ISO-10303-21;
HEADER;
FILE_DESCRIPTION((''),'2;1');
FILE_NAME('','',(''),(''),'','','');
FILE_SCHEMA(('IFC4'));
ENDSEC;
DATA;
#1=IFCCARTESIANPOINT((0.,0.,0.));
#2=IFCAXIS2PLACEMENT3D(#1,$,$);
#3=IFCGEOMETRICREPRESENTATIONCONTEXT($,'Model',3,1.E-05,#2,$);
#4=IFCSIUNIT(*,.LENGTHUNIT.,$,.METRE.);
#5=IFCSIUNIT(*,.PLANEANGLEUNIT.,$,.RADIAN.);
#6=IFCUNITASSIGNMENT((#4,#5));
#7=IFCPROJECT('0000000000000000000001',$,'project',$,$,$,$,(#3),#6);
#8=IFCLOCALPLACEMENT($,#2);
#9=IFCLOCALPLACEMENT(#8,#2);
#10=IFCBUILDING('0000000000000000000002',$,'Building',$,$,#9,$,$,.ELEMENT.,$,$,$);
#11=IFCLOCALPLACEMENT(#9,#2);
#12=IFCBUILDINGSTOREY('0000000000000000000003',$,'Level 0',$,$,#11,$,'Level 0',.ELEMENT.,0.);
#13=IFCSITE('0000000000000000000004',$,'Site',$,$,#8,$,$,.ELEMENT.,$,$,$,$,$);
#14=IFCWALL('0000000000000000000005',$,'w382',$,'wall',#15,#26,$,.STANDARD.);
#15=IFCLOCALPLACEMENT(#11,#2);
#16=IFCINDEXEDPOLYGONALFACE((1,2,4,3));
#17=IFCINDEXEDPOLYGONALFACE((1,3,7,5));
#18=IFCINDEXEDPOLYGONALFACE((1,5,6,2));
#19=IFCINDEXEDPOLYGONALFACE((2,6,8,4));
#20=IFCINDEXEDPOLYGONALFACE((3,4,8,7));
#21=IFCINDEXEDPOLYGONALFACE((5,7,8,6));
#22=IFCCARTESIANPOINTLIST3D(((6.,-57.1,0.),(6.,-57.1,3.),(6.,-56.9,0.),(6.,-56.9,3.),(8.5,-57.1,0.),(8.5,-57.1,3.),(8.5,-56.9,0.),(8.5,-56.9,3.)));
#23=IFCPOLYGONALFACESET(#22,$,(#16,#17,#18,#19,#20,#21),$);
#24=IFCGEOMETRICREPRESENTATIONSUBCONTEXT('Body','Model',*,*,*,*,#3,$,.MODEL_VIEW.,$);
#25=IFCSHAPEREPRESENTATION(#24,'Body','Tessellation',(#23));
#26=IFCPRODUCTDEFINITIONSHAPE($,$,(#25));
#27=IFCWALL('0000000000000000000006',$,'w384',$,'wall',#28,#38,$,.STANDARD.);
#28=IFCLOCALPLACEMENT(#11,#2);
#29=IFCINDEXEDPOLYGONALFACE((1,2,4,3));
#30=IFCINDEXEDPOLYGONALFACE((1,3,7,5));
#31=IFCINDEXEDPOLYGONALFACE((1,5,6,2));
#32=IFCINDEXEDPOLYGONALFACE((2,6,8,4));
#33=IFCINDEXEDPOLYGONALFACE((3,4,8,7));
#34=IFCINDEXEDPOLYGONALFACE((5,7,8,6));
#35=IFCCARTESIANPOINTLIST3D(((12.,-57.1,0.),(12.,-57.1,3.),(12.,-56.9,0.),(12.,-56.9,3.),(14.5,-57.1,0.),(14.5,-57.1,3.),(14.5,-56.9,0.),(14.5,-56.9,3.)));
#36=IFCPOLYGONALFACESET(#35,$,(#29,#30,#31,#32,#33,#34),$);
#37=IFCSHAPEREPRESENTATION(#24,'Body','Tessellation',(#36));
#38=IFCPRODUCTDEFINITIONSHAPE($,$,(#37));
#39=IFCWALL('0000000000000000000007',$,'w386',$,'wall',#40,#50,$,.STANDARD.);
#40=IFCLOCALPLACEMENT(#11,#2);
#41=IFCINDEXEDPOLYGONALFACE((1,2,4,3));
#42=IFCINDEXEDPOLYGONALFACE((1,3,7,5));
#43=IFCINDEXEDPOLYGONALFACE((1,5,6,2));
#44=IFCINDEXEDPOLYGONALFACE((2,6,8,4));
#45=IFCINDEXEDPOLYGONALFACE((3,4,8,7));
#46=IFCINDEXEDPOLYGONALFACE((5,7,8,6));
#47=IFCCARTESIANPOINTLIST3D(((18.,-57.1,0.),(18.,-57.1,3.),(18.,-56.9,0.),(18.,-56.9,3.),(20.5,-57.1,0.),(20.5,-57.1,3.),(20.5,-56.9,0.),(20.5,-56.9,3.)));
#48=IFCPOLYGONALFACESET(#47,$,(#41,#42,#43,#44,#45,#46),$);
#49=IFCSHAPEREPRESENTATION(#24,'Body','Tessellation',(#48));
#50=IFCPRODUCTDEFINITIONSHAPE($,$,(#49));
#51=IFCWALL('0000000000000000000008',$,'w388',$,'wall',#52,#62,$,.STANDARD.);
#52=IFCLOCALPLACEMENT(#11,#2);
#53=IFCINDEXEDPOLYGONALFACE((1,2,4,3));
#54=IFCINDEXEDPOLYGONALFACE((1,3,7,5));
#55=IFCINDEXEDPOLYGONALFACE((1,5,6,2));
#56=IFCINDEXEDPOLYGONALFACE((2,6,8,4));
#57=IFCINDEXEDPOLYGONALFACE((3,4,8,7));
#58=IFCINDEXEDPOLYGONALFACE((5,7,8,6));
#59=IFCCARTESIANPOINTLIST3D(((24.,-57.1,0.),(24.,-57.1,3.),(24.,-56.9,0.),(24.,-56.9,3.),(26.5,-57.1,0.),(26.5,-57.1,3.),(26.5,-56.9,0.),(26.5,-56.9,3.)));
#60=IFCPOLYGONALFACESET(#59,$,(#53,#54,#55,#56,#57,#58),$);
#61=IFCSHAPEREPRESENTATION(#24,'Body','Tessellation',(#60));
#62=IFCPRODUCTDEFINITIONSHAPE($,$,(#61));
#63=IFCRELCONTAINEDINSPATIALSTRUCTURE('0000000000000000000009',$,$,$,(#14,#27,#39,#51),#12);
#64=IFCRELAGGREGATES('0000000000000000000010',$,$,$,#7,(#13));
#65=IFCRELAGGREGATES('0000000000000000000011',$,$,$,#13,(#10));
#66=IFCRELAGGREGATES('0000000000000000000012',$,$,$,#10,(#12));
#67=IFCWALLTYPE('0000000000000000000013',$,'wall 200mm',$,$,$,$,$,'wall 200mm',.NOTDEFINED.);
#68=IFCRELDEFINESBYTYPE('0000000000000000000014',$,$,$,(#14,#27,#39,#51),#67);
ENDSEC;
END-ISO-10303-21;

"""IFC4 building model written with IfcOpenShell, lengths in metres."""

from ifc_helpers import new_model, si_unit, frame, frame_2d, origin, place, context, subcontext, project, spatial, rectangle, extrude, type_object, element, save


model = new_model("IFC4")

# Units and contexts
model_context = context("Model", 3, precision=1e-05, world=origin())
body_context = subcontext(model_context, "Body", "Model", "MODEL_VIEW")
ifc_project = project(units=[si_unit("LENGTHUNIT", "METRE"), si_unit("PLANEANGLEUNIT", "RADIAN")], contexts=[model_context])

# Site, building, storey
site_placement = place(None, origin())
site = spatial("IfcSite", under=ifc_project, at=site_placement, Name="Site", CompositionType="ELEMENT")
building_placement = place(site_placement, origin())
building = spatial("IfcBuilding", under=site, at=building_placement, Name="Building", CompositionType="ELEMENT")
storey_placement = place(building_placement, origin())
storey = spatial("IfcBuildingStorey", under=building, at=storey_placement, Name="Level 0", LongName="Level 0", CompositionType="ELEMENT", Elevation=0.0)

# Walls
wall_type = type_object("IfcWallType", Name="wall 200mm", ElementType="wall 200mm", PredefinedType="NOTDEFINED")
for number, where, z_axis, x_axis, name in (
    (1, (6.0, -57.0, 0.0), (0.0, 0.0, 1.0), (1.0, 0.0, 0.0), "w382"),
    (2, (12.0, -57.0, 0.0), (0.0, 0.0, 1.0), (1.0, 0.0, 0.0), "w384"),
    (3, (18.0, -57.0, 0.0), (0.0, 0.0, 1.0), (1.0, 0.0, 0.0), "w386"),
    (4, (24.0, -57.0, 0.0), (0.0, 0.0, 1.0), (1.0, 0.0, 0.0), "w388"),
):
    element("IfcWall", number, at=place(storey_placement, frame(where, z_axis=z_axis, x_axis=x_axis)), inside=storey, type_object=wall_type, Name=name, ObjectType="wall", PredefinedType="STANDARD", context=body_context, shape_type="SweptSolid", body=[
        extrude(rectangle(XDim=2.5, YDim=0.2, at=frame_2d((1.25, 0.0))), origin(), (0.0, 0.0, 1.0), 3.0),
    ])

save(model, "model.ifc")
